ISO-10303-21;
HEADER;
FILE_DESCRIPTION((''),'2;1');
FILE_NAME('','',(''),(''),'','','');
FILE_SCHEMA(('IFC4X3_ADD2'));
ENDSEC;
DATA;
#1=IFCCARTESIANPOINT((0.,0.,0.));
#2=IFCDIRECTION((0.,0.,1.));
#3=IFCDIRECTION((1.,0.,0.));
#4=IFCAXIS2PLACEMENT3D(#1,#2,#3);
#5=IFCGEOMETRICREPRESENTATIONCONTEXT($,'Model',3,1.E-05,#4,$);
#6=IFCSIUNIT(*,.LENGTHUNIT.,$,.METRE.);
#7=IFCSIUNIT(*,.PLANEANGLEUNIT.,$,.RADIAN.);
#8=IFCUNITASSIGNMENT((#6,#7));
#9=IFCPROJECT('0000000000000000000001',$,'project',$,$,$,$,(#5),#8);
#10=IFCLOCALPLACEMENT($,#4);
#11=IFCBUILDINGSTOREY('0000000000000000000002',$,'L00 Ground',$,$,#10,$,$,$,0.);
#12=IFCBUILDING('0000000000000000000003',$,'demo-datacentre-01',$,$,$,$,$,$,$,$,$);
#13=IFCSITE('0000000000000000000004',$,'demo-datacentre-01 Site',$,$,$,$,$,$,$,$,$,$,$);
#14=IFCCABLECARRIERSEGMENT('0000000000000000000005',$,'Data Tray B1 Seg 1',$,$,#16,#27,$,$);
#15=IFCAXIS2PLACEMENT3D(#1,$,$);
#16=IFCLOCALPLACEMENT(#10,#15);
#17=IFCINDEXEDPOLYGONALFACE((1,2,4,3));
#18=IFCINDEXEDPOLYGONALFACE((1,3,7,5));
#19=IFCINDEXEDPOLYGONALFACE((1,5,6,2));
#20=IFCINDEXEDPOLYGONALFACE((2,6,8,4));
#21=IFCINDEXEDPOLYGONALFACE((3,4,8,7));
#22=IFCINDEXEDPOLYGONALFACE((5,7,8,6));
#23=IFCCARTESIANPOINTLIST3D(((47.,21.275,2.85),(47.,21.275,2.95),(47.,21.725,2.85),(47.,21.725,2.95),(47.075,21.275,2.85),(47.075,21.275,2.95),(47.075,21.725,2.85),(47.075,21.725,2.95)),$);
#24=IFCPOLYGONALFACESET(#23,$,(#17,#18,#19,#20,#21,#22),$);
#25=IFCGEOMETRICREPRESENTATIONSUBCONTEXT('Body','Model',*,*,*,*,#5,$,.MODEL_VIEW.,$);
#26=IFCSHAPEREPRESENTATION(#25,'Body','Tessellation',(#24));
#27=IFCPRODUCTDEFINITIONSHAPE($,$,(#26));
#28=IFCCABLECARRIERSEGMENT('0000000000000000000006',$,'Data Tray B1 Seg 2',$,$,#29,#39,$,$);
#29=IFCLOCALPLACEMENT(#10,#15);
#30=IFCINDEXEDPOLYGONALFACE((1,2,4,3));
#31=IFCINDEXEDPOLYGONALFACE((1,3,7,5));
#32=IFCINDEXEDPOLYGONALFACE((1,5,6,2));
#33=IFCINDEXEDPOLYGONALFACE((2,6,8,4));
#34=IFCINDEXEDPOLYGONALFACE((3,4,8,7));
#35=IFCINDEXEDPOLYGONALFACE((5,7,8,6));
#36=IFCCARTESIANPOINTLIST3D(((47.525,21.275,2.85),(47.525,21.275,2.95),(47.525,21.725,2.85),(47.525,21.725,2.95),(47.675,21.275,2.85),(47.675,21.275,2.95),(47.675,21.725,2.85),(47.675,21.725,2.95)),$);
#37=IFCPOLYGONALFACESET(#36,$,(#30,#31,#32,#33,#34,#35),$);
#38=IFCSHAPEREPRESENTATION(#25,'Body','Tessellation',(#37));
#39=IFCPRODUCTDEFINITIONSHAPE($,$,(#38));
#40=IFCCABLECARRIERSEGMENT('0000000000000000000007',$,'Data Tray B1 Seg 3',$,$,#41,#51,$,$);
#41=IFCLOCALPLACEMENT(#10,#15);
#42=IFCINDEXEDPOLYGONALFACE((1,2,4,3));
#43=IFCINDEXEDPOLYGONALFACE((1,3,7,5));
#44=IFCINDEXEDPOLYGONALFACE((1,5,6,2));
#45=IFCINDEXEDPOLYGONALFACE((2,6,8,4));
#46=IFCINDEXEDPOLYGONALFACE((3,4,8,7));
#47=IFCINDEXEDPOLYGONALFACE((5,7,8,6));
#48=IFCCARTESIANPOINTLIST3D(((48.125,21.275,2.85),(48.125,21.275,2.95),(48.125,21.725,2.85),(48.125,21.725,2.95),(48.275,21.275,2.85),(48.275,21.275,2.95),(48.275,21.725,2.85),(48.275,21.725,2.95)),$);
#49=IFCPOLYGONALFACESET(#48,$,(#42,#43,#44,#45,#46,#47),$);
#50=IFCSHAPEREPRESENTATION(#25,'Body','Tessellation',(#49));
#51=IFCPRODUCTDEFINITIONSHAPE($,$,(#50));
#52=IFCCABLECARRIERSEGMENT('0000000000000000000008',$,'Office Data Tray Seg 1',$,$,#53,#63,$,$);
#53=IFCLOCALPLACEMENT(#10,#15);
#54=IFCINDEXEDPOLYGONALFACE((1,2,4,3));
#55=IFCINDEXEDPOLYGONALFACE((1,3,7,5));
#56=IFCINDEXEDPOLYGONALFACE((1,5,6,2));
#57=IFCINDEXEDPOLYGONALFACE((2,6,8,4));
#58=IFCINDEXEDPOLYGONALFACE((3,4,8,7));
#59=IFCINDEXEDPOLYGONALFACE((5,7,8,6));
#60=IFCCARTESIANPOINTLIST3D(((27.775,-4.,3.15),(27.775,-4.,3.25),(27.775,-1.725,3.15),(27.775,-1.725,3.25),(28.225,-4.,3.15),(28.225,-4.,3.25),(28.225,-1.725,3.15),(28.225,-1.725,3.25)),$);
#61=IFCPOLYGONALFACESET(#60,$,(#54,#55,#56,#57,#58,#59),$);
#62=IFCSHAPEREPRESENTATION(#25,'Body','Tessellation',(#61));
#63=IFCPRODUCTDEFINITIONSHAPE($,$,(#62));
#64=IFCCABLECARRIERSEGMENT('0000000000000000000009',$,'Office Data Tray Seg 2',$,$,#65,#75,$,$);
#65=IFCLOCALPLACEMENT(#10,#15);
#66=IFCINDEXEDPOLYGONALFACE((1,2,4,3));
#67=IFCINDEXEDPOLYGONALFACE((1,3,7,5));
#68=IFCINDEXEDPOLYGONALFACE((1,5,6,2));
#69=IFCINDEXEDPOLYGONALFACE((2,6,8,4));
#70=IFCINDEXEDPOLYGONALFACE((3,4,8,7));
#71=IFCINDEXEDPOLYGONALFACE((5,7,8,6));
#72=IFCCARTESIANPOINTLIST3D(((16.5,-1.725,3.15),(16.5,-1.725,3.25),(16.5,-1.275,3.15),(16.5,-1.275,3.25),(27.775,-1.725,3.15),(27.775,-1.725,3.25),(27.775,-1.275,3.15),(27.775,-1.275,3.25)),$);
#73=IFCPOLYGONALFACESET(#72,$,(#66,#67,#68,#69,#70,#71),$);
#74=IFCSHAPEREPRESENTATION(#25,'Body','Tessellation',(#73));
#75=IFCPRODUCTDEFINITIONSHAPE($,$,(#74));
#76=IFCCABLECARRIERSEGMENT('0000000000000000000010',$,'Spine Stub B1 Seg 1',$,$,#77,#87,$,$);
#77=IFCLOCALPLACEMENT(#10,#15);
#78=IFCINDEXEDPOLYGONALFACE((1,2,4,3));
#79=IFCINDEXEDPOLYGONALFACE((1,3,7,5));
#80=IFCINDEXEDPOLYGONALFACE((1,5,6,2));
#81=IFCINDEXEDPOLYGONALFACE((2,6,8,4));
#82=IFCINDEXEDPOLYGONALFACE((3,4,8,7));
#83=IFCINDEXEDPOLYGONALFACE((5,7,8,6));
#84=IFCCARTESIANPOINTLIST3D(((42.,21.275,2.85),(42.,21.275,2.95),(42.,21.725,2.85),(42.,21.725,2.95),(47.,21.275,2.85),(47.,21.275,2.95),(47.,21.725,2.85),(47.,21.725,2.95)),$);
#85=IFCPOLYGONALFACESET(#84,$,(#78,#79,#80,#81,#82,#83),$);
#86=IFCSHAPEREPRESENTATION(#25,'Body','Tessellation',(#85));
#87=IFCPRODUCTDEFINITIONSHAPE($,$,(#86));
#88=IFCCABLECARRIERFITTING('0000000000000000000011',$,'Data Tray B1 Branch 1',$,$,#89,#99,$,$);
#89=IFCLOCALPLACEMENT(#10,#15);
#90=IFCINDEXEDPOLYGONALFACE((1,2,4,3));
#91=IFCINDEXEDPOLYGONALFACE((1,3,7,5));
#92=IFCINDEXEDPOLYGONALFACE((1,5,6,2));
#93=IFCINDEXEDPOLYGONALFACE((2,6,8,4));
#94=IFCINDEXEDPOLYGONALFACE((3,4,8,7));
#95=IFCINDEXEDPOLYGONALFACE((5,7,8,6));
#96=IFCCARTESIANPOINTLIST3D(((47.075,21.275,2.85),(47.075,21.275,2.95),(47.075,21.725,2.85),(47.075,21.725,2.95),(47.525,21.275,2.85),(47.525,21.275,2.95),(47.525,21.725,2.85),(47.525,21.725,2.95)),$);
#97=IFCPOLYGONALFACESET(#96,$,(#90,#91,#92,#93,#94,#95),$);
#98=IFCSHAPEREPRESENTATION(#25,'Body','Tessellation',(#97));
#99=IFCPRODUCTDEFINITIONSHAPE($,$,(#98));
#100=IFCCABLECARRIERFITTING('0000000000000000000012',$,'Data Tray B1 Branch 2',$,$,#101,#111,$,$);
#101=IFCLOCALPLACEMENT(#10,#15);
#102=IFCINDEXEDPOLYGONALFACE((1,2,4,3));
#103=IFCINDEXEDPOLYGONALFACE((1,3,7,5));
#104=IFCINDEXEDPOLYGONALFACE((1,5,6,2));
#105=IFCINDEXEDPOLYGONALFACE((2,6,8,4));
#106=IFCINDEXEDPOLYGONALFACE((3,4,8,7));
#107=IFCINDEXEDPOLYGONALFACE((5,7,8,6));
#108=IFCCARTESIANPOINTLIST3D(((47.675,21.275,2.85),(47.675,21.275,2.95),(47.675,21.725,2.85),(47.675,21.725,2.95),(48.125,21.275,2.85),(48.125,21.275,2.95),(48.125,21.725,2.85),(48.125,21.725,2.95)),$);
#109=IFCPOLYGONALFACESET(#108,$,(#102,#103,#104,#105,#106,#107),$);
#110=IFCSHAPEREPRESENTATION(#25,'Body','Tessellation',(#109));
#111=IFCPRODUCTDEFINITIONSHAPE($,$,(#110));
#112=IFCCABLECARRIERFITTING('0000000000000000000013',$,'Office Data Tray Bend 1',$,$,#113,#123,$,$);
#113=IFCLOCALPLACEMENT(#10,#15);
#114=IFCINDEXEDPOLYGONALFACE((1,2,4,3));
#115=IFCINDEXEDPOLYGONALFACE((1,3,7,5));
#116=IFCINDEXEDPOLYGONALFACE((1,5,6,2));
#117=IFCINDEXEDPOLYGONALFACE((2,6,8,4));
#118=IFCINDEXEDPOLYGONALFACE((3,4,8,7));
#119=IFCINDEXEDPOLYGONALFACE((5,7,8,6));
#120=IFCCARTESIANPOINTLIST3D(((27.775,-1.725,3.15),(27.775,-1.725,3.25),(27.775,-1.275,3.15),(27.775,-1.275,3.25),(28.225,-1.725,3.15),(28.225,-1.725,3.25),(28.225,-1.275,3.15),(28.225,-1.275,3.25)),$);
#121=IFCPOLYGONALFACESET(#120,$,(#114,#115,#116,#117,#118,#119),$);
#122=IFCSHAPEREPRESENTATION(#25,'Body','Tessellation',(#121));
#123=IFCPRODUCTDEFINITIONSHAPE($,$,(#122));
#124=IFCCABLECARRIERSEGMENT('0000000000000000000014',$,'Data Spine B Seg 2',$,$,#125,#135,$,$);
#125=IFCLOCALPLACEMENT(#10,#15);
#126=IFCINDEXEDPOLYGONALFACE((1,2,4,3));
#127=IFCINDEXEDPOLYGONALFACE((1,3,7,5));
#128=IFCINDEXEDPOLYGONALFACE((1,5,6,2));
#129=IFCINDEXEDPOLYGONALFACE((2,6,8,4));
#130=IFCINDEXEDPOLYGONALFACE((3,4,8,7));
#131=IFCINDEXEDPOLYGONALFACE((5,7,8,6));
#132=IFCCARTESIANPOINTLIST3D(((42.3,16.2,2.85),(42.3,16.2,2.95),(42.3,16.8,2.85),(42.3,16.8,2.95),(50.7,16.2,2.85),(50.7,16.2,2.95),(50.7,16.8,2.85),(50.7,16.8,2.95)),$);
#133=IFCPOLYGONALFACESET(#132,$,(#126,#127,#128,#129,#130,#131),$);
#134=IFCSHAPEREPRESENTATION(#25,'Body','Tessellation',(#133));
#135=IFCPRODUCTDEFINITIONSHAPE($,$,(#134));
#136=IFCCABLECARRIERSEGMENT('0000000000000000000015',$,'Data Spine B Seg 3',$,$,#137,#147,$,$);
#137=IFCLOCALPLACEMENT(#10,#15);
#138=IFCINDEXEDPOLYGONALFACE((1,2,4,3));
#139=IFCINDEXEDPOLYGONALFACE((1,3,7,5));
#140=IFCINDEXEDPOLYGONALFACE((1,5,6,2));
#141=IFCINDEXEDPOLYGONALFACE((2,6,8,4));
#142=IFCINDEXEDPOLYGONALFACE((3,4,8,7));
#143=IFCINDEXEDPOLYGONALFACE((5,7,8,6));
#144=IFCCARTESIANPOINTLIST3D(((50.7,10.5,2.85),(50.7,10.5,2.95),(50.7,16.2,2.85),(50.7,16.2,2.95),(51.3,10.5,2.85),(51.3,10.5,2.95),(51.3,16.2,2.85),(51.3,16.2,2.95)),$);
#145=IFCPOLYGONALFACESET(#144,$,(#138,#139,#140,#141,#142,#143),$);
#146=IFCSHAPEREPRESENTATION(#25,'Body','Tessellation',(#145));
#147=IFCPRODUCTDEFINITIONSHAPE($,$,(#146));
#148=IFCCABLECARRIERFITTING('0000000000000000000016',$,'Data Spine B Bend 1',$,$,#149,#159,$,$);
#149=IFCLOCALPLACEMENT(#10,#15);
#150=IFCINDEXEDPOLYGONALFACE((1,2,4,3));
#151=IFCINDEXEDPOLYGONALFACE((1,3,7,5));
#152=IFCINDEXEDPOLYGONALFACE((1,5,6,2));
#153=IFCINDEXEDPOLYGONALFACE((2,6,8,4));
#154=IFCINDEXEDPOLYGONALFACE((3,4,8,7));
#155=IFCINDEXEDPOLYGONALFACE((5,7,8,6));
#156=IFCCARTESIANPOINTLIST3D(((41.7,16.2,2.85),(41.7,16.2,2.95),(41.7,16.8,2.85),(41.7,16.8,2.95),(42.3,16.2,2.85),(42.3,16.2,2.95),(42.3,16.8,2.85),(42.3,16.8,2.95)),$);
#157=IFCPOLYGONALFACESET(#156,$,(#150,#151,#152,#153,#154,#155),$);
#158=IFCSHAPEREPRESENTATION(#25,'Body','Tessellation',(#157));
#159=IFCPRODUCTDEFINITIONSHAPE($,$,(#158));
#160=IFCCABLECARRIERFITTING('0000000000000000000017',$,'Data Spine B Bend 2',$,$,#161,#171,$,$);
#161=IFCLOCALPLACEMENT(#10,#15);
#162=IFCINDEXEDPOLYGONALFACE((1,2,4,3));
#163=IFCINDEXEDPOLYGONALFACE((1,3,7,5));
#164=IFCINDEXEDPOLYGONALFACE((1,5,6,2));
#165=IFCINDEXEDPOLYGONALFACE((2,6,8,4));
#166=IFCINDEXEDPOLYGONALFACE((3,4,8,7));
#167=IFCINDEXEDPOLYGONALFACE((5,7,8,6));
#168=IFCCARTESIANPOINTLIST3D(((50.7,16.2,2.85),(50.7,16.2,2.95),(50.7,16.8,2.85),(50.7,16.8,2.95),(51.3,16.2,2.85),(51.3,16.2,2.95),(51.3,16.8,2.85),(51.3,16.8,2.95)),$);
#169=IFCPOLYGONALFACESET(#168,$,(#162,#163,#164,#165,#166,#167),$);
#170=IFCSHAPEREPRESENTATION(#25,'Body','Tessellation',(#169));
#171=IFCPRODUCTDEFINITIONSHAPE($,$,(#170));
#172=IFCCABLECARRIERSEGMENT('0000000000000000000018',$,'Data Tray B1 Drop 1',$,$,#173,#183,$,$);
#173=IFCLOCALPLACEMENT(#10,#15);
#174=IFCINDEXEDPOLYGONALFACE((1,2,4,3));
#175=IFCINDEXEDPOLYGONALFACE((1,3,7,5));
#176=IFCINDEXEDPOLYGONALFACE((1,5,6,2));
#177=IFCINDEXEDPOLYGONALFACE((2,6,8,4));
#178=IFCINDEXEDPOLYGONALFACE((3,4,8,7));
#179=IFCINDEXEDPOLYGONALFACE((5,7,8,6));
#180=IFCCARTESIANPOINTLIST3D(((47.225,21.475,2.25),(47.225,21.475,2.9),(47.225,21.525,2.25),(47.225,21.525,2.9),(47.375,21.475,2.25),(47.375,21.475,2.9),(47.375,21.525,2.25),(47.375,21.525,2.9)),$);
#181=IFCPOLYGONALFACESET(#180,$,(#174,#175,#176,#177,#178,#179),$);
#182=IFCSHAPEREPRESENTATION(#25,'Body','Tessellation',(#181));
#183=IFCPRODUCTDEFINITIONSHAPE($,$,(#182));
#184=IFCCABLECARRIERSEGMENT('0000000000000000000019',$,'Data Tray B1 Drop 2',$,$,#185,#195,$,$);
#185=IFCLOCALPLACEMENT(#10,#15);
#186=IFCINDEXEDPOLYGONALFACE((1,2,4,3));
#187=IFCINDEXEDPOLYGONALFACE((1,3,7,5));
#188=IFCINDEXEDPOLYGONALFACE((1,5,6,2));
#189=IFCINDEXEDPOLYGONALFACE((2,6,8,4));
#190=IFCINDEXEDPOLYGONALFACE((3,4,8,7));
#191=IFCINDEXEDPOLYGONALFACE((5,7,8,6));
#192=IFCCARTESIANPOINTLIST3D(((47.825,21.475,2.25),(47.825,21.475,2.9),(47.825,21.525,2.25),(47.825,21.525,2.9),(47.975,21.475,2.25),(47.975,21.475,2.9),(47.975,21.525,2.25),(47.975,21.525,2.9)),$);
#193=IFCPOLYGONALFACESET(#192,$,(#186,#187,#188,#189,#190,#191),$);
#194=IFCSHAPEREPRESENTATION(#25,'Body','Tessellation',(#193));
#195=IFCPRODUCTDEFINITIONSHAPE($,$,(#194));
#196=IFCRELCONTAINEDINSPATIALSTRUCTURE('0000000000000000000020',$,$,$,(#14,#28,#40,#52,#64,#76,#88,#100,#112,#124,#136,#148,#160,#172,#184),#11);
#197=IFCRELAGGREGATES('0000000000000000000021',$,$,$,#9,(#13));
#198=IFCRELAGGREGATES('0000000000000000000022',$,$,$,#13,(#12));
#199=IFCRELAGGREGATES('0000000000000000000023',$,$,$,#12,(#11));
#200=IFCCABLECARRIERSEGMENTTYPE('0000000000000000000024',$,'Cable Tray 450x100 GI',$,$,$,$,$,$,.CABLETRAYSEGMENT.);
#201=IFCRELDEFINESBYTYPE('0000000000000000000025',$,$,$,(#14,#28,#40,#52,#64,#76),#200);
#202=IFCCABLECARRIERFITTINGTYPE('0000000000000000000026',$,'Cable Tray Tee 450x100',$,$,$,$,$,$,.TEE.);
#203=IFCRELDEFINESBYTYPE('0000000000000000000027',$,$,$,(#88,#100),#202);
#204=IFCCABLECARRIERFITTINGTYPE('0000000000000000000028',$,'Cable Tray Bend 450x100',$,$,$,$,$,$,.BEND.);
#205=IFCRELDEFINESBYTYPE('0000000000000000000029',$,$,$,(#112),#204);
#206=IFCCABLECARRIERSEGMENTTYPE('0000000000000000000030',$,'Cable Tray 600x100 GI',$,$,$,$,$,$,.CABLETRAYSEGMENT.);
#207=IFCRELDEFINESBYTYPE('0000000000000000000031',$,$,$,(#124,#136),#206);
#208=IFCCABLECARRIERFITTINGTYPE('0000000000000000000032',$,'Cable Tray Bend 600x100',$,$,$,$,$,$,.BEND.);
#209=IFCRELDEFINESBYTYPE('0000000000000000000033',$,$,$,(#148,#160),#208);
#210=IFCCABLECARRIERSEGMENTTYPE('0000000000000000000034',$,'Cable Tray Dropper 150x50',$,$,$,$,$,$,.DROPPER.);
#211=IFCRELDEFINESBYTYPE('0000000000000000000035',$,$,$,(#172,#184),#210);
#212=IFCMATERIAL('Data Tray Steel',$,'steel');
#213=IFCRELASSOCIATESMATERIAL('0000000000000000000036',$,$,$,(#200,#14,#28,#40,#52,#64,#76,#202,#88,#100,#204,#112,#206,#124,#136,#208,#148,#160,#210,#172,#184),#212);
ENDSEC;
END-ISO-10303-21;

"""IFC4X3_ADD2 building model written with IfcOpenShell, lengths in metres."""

from ifc_helpers import new_model, si_unit, frame, origin_with_axes, place, context, subcontext, project, spatial, rectangle, extrude, material, type_object, element, save


model = new_model("IFC4X3_ADD2")

# Units and contexts
model_context = context("Model", 3, precision=1e-05, world=origin_with_axes())
body_context = subcontext(model_context, "Body", "Model", "MODEL_VIEW")
ifc_project = project(units=[si_unit("LENGTHUNIT", "METRE"), si_unit("PLANEANGLEUNIT", "RADIAN")], contexts=[model_context])

# Site, building, storey
site = spatial("IfcSite", under=ifc_project, Name="demo-datacentre-01 Site")
building = spatial("IfcBuilding", under=site, Name="demo-datacentre-01")
storey_placement = place(None, origin_with_axes())
storey = spatial("IfcBuildingStorey", under=building, at=storey_placement, Name="L00 Ground", Elevation=0.0)

# Cable carrier segments
ifc_material_1 = material(Name="Data Tray Steel", Category="steel")
cable_carrier_segment_type_1 = type_object("IfcCableCarrierSegmentType", Name="Cable Tray 450x100 GI", PredefinedType="CABLETRAYSEGMENT", material=ifc_material_1)
cable_carrier_segment_1_placement = place(storey_placement, frame((47.0, 21.5, 2.9), z_axis=(1.0, 0.0, 0.0), x_axis=(0.0, 1.0, 0.0)))
element("IfcCableCarrierSegment", 1, at=cable_carrier_segment_1_placement, inside=storey, type_object=cable_carrier_segment_type_1, material=ifc_material_1, Name="Data Tray B1 Seg 1", context=body_context, shape_type="SweptSolid", body=[
    extrude(rectangle(XDim=0.45, YDim=0.1), origin_with_axes(), (0.0, 0.0, 1.0), 0.075),
])
for number, where, z_axis, x_axis, name in (
    (2, (47.525, 21.5, 2.9), (1.0, 0.0, 0.0), (0.0, 1.0, 0.0), "Data Tray B1 Seg 2"),
    (3, (48.125, 21.5, 2.9), (1.0, 0.0, 0.0), (0.0, 1.0, 0.0), "Data Tray B1 Seg 3"),
):
    element("IfcCableCarrierSegment", number, at=place(storey_placement, frame(where, z_axis=z_axis, x_axis=x_axis)), inside=storey, type_object=cable_carrier_segment_type_1, material=ifc_material_1, Name=name, context=body_context, shape_type="SweptSolid", body=[
        extrude(rectangle(XDim=0.45, YDim=0.1), origin_with_axes(), (0.0, 0.0, 1.0), 0.15),
    ])
cable_carrier_segment_2_placement = place(storey_placement, frame((28.0, -4.0, 3.2), z_axis=(0.0, 1.0, 0.0), x_axis=(-1.0, 0.0, 0.0)))
element("IfcCableCarrierSegment", 4, at=cable_carrier_segment_2_placement, inside=storey, type_object=cable_carrier_segment_type_1, material=ifc_material_1, Name="Office Data Tray Seg 1", context=body_context, shape_type="SweptSolid", body=[
    extrude(rectangle(XDim=0.45, YDim=0.1), origin_with_axes(), (0.0, 0.0, 1.0), 2.275),
])
cable_carrier_segment_3_placement = place(storey_placement, frame((27.775, -1.5, 3.2), z_axis=(-1.0, 0.0, 0.0), x_axis=(0.0, -1.0, 0.0)))
element("IfcCableCarrierSegment", 5, at=cable_carrier_segment_3_placement, inside=storey, type_object=cable_carrier_segment_type_1, material=ifc_material_1, Name="Office Data Tray Seg 2", context=body_context, shape_type="SweptSolid", body=[
    extrude(rectangle(XDim=0.45, YDim=0.1), origin_with_axes(), (0.0, 0.0, 1.0), 11.275),
])
cable_carrier_segment_4_placement = place(storey_placement, frame((42.0, 21.5, 2.9), z_axis=(1.0, 0.0, 0.0), x_axis=(0.0, 1.0, 0.0)))
element("IfcCableCarrierSegment", 6, at=cable_carrier_segment_4_placement, inside=storey, type_object=cable_carrier_segment_type_1, material=ifc_material_1, Name="Spine Stub B1 Seg 1", context=body_context, shape_type="SweptSolid", body=[
    extrude(rectangle(XDim=0.45, YDim=0.1), origin_with_axes(), (0.0, 0.0, 1.0), 5.0),
])

# Cable carrier fittings
cable_carrier_fitting_type_1 = type_object("IfcCableCarrierFittingType", Name="Cable Tray Tee 450x100", PredefinedType="TEE", material=ifc_material_1)
for number, where, z_axis, x_axis, name in (
    (7, (47.3, 21.5, 2.85), (0.0, 0.0, 1.0), (1.0, 0.0, 0.0), "Data Tray B1 Branch 1"),
    (8, (47.9, 21.5, 2.85), (0.0, 0.0, 1.0), (1.0, 0.0, 0.0), "Data Tray B1 Branch 2"),
):
    element("IfcCableCarrierFitting", number, at=place(storey_placement, frame(where, z_axis=z_axis, x_axis=x_axis)), inside=storey, type_object=cable_carrier_fitting_type_1, material=ifc_material_1, Name=name, context=body_context, shape_type="SweptSolid", body=[
        extrude(rectangle(XDim=0.45, YDim=0.45), origin_with_axes(), (0.0, 0.0, 1.0), 0.1),
    ])
cable_carrier_fitting_type_2 = type_object("IfcCableCarrierFittingType", Name="Cable Tray Bend 450x100", PredefinedType="BEND", material=ifc_material_1)
cable_carrier_fitting_placement = place(storey_placement, frame((28.0, -1.5, 3.15), z_axis=(0.0, 0.0, 1.0), x_axis=(1.0, 0.0, 0.0)))
element("IfcCableCarrierFitting", 9, at=cable_carrier_fitting_placement, inside=storey, type_object=cable_carrier_fitting_type_2, material=ifc_material_1, Name="Office Data Tray Bend 1", context=body_context, shape_type="SweptSolid", body=[
    extrude(rectangle(XDim=0.45, YDim=0.45), origin_with_axes(), (0.0, 0.0, 1.0), 0.1),
])

# Cable carrier segments
cable_carrier_segment_type_2 = type_object("IfcCableCarrierSegmentType", Name="Cable Tray 600x100 GI", PredefinedType="CABLETRAYSEGMENT", material=ifc_material_1)
cable_carrier_segment_5_placement = place(storey_placement, frame((42.3, 16.5, 2.9), z_axis=(1.0, 0.0, 0.0), x_axis=(0.0, 1.0, 0.0)))
element("IfcCableCarrierSegment", 10, at=cable_carrier_segment_5_placement, inside=storey, type_object=cable_carrier_segment_type_2, material=ifc_material_1, Name="Data Spine B Seg 2", context=body_context, shape_type="SweptSolid", body=[
    extrude(rectangle(XDim=0.6, YDim=0.1), origin_with_axes(), (0.0, 0.0, 1.0), 8.4),
])
cable_carrier_segment_6_placement = place(storey_placement, frame((51.0, 16.2, 2.9), z_axis=(0.0, -1.0, 0.0), x_axis=(1.0, 0.0, 0.0)))
element("IfcCableCarrierSegment", 11, at=cable_carrier_segment_6_placement, inside=storey, type_object=cable_carrier_segment_type_2, material=ifc_material_1, Name="Data Spine B Seg 3", context=body_context, shape_type="SweptSolid", body=[
    extrude(rectangle(XDim=0.6, YDim=0.1), origin_with_axes(), (0.0, 0.0, 1.0), 5.7),
])

# Cable carrier fittings
cable_carrier_fitting_type_3 = type_object("IfcCableCarrierFittingType", Name="Cable Tray Bend 600x100", PredefinedType="BEND", material=ifc_material_1)
for number, where, z_axis, x_axis, name in (
    (12, (42.0, 16.5, 2.85), (0.0, 0.0, 1.0), (1.0, 0.0, 0.0), "Data Spine B Bend 1"),
    (13, (51.0, 16.5, 2.85), (0.0, 0.0, 1.0), (1.0, 0.0, 0.0), "Data Spine B Bend 2"),
):
    element("IfcCableCarrierFitting", number, at=place(storey_placement, frame(where, z_axis=z_axis, x_axis=x_axis)), inside=storey, type_object=cable_carrier_fitting_type_3, material=ifc_material_1, Name=name, context=body_context, shape_type="SweptSolid", body=[
        extrude(rectangle(XDim=0.6, YDim=0.6), origin_with_axes(), (0.0, 0.0, 1.0), 0.1),
    ])

# Cable carrier segments
cable_carrier_segment_type_3 = type_object("IfcCableCarrierSegmentType", Name="Cable Tray Dropper 150x50", PredefinedType="DROPPER", material=ifc_material_1)
for number, where, z_axis, x_axis, name in (
    (14, (47.3, 21.5, 2.9), (0.0, 0.0, -1.0), (1.0, 0.0, 0.0), "Data Tray B1 Drop 1"),
    (15, (47.9, 21.5, 2.9), (0.0, 0.0, -1.0), (1.0, 0.0, 0.0), "Data Tray B1 Drop 2"),
):
    element("IfcCableCarrierSegment", number, at=place(storey_placement, frame(where, z_axis=z_axis, x_axis=x_axis)), inside=storey, type_object=cable_carrier_segment_type_3, material=ifc_material_1, Name=name, context=body_context, shape_type="SweptSolid", body=[
        extrude(rectangle(XDim=0.15, YDim=0.05), origin_with_axes(), (0.0, 0.0, 1.0), 0.65),
    ])

save(model, "model.ifc")
